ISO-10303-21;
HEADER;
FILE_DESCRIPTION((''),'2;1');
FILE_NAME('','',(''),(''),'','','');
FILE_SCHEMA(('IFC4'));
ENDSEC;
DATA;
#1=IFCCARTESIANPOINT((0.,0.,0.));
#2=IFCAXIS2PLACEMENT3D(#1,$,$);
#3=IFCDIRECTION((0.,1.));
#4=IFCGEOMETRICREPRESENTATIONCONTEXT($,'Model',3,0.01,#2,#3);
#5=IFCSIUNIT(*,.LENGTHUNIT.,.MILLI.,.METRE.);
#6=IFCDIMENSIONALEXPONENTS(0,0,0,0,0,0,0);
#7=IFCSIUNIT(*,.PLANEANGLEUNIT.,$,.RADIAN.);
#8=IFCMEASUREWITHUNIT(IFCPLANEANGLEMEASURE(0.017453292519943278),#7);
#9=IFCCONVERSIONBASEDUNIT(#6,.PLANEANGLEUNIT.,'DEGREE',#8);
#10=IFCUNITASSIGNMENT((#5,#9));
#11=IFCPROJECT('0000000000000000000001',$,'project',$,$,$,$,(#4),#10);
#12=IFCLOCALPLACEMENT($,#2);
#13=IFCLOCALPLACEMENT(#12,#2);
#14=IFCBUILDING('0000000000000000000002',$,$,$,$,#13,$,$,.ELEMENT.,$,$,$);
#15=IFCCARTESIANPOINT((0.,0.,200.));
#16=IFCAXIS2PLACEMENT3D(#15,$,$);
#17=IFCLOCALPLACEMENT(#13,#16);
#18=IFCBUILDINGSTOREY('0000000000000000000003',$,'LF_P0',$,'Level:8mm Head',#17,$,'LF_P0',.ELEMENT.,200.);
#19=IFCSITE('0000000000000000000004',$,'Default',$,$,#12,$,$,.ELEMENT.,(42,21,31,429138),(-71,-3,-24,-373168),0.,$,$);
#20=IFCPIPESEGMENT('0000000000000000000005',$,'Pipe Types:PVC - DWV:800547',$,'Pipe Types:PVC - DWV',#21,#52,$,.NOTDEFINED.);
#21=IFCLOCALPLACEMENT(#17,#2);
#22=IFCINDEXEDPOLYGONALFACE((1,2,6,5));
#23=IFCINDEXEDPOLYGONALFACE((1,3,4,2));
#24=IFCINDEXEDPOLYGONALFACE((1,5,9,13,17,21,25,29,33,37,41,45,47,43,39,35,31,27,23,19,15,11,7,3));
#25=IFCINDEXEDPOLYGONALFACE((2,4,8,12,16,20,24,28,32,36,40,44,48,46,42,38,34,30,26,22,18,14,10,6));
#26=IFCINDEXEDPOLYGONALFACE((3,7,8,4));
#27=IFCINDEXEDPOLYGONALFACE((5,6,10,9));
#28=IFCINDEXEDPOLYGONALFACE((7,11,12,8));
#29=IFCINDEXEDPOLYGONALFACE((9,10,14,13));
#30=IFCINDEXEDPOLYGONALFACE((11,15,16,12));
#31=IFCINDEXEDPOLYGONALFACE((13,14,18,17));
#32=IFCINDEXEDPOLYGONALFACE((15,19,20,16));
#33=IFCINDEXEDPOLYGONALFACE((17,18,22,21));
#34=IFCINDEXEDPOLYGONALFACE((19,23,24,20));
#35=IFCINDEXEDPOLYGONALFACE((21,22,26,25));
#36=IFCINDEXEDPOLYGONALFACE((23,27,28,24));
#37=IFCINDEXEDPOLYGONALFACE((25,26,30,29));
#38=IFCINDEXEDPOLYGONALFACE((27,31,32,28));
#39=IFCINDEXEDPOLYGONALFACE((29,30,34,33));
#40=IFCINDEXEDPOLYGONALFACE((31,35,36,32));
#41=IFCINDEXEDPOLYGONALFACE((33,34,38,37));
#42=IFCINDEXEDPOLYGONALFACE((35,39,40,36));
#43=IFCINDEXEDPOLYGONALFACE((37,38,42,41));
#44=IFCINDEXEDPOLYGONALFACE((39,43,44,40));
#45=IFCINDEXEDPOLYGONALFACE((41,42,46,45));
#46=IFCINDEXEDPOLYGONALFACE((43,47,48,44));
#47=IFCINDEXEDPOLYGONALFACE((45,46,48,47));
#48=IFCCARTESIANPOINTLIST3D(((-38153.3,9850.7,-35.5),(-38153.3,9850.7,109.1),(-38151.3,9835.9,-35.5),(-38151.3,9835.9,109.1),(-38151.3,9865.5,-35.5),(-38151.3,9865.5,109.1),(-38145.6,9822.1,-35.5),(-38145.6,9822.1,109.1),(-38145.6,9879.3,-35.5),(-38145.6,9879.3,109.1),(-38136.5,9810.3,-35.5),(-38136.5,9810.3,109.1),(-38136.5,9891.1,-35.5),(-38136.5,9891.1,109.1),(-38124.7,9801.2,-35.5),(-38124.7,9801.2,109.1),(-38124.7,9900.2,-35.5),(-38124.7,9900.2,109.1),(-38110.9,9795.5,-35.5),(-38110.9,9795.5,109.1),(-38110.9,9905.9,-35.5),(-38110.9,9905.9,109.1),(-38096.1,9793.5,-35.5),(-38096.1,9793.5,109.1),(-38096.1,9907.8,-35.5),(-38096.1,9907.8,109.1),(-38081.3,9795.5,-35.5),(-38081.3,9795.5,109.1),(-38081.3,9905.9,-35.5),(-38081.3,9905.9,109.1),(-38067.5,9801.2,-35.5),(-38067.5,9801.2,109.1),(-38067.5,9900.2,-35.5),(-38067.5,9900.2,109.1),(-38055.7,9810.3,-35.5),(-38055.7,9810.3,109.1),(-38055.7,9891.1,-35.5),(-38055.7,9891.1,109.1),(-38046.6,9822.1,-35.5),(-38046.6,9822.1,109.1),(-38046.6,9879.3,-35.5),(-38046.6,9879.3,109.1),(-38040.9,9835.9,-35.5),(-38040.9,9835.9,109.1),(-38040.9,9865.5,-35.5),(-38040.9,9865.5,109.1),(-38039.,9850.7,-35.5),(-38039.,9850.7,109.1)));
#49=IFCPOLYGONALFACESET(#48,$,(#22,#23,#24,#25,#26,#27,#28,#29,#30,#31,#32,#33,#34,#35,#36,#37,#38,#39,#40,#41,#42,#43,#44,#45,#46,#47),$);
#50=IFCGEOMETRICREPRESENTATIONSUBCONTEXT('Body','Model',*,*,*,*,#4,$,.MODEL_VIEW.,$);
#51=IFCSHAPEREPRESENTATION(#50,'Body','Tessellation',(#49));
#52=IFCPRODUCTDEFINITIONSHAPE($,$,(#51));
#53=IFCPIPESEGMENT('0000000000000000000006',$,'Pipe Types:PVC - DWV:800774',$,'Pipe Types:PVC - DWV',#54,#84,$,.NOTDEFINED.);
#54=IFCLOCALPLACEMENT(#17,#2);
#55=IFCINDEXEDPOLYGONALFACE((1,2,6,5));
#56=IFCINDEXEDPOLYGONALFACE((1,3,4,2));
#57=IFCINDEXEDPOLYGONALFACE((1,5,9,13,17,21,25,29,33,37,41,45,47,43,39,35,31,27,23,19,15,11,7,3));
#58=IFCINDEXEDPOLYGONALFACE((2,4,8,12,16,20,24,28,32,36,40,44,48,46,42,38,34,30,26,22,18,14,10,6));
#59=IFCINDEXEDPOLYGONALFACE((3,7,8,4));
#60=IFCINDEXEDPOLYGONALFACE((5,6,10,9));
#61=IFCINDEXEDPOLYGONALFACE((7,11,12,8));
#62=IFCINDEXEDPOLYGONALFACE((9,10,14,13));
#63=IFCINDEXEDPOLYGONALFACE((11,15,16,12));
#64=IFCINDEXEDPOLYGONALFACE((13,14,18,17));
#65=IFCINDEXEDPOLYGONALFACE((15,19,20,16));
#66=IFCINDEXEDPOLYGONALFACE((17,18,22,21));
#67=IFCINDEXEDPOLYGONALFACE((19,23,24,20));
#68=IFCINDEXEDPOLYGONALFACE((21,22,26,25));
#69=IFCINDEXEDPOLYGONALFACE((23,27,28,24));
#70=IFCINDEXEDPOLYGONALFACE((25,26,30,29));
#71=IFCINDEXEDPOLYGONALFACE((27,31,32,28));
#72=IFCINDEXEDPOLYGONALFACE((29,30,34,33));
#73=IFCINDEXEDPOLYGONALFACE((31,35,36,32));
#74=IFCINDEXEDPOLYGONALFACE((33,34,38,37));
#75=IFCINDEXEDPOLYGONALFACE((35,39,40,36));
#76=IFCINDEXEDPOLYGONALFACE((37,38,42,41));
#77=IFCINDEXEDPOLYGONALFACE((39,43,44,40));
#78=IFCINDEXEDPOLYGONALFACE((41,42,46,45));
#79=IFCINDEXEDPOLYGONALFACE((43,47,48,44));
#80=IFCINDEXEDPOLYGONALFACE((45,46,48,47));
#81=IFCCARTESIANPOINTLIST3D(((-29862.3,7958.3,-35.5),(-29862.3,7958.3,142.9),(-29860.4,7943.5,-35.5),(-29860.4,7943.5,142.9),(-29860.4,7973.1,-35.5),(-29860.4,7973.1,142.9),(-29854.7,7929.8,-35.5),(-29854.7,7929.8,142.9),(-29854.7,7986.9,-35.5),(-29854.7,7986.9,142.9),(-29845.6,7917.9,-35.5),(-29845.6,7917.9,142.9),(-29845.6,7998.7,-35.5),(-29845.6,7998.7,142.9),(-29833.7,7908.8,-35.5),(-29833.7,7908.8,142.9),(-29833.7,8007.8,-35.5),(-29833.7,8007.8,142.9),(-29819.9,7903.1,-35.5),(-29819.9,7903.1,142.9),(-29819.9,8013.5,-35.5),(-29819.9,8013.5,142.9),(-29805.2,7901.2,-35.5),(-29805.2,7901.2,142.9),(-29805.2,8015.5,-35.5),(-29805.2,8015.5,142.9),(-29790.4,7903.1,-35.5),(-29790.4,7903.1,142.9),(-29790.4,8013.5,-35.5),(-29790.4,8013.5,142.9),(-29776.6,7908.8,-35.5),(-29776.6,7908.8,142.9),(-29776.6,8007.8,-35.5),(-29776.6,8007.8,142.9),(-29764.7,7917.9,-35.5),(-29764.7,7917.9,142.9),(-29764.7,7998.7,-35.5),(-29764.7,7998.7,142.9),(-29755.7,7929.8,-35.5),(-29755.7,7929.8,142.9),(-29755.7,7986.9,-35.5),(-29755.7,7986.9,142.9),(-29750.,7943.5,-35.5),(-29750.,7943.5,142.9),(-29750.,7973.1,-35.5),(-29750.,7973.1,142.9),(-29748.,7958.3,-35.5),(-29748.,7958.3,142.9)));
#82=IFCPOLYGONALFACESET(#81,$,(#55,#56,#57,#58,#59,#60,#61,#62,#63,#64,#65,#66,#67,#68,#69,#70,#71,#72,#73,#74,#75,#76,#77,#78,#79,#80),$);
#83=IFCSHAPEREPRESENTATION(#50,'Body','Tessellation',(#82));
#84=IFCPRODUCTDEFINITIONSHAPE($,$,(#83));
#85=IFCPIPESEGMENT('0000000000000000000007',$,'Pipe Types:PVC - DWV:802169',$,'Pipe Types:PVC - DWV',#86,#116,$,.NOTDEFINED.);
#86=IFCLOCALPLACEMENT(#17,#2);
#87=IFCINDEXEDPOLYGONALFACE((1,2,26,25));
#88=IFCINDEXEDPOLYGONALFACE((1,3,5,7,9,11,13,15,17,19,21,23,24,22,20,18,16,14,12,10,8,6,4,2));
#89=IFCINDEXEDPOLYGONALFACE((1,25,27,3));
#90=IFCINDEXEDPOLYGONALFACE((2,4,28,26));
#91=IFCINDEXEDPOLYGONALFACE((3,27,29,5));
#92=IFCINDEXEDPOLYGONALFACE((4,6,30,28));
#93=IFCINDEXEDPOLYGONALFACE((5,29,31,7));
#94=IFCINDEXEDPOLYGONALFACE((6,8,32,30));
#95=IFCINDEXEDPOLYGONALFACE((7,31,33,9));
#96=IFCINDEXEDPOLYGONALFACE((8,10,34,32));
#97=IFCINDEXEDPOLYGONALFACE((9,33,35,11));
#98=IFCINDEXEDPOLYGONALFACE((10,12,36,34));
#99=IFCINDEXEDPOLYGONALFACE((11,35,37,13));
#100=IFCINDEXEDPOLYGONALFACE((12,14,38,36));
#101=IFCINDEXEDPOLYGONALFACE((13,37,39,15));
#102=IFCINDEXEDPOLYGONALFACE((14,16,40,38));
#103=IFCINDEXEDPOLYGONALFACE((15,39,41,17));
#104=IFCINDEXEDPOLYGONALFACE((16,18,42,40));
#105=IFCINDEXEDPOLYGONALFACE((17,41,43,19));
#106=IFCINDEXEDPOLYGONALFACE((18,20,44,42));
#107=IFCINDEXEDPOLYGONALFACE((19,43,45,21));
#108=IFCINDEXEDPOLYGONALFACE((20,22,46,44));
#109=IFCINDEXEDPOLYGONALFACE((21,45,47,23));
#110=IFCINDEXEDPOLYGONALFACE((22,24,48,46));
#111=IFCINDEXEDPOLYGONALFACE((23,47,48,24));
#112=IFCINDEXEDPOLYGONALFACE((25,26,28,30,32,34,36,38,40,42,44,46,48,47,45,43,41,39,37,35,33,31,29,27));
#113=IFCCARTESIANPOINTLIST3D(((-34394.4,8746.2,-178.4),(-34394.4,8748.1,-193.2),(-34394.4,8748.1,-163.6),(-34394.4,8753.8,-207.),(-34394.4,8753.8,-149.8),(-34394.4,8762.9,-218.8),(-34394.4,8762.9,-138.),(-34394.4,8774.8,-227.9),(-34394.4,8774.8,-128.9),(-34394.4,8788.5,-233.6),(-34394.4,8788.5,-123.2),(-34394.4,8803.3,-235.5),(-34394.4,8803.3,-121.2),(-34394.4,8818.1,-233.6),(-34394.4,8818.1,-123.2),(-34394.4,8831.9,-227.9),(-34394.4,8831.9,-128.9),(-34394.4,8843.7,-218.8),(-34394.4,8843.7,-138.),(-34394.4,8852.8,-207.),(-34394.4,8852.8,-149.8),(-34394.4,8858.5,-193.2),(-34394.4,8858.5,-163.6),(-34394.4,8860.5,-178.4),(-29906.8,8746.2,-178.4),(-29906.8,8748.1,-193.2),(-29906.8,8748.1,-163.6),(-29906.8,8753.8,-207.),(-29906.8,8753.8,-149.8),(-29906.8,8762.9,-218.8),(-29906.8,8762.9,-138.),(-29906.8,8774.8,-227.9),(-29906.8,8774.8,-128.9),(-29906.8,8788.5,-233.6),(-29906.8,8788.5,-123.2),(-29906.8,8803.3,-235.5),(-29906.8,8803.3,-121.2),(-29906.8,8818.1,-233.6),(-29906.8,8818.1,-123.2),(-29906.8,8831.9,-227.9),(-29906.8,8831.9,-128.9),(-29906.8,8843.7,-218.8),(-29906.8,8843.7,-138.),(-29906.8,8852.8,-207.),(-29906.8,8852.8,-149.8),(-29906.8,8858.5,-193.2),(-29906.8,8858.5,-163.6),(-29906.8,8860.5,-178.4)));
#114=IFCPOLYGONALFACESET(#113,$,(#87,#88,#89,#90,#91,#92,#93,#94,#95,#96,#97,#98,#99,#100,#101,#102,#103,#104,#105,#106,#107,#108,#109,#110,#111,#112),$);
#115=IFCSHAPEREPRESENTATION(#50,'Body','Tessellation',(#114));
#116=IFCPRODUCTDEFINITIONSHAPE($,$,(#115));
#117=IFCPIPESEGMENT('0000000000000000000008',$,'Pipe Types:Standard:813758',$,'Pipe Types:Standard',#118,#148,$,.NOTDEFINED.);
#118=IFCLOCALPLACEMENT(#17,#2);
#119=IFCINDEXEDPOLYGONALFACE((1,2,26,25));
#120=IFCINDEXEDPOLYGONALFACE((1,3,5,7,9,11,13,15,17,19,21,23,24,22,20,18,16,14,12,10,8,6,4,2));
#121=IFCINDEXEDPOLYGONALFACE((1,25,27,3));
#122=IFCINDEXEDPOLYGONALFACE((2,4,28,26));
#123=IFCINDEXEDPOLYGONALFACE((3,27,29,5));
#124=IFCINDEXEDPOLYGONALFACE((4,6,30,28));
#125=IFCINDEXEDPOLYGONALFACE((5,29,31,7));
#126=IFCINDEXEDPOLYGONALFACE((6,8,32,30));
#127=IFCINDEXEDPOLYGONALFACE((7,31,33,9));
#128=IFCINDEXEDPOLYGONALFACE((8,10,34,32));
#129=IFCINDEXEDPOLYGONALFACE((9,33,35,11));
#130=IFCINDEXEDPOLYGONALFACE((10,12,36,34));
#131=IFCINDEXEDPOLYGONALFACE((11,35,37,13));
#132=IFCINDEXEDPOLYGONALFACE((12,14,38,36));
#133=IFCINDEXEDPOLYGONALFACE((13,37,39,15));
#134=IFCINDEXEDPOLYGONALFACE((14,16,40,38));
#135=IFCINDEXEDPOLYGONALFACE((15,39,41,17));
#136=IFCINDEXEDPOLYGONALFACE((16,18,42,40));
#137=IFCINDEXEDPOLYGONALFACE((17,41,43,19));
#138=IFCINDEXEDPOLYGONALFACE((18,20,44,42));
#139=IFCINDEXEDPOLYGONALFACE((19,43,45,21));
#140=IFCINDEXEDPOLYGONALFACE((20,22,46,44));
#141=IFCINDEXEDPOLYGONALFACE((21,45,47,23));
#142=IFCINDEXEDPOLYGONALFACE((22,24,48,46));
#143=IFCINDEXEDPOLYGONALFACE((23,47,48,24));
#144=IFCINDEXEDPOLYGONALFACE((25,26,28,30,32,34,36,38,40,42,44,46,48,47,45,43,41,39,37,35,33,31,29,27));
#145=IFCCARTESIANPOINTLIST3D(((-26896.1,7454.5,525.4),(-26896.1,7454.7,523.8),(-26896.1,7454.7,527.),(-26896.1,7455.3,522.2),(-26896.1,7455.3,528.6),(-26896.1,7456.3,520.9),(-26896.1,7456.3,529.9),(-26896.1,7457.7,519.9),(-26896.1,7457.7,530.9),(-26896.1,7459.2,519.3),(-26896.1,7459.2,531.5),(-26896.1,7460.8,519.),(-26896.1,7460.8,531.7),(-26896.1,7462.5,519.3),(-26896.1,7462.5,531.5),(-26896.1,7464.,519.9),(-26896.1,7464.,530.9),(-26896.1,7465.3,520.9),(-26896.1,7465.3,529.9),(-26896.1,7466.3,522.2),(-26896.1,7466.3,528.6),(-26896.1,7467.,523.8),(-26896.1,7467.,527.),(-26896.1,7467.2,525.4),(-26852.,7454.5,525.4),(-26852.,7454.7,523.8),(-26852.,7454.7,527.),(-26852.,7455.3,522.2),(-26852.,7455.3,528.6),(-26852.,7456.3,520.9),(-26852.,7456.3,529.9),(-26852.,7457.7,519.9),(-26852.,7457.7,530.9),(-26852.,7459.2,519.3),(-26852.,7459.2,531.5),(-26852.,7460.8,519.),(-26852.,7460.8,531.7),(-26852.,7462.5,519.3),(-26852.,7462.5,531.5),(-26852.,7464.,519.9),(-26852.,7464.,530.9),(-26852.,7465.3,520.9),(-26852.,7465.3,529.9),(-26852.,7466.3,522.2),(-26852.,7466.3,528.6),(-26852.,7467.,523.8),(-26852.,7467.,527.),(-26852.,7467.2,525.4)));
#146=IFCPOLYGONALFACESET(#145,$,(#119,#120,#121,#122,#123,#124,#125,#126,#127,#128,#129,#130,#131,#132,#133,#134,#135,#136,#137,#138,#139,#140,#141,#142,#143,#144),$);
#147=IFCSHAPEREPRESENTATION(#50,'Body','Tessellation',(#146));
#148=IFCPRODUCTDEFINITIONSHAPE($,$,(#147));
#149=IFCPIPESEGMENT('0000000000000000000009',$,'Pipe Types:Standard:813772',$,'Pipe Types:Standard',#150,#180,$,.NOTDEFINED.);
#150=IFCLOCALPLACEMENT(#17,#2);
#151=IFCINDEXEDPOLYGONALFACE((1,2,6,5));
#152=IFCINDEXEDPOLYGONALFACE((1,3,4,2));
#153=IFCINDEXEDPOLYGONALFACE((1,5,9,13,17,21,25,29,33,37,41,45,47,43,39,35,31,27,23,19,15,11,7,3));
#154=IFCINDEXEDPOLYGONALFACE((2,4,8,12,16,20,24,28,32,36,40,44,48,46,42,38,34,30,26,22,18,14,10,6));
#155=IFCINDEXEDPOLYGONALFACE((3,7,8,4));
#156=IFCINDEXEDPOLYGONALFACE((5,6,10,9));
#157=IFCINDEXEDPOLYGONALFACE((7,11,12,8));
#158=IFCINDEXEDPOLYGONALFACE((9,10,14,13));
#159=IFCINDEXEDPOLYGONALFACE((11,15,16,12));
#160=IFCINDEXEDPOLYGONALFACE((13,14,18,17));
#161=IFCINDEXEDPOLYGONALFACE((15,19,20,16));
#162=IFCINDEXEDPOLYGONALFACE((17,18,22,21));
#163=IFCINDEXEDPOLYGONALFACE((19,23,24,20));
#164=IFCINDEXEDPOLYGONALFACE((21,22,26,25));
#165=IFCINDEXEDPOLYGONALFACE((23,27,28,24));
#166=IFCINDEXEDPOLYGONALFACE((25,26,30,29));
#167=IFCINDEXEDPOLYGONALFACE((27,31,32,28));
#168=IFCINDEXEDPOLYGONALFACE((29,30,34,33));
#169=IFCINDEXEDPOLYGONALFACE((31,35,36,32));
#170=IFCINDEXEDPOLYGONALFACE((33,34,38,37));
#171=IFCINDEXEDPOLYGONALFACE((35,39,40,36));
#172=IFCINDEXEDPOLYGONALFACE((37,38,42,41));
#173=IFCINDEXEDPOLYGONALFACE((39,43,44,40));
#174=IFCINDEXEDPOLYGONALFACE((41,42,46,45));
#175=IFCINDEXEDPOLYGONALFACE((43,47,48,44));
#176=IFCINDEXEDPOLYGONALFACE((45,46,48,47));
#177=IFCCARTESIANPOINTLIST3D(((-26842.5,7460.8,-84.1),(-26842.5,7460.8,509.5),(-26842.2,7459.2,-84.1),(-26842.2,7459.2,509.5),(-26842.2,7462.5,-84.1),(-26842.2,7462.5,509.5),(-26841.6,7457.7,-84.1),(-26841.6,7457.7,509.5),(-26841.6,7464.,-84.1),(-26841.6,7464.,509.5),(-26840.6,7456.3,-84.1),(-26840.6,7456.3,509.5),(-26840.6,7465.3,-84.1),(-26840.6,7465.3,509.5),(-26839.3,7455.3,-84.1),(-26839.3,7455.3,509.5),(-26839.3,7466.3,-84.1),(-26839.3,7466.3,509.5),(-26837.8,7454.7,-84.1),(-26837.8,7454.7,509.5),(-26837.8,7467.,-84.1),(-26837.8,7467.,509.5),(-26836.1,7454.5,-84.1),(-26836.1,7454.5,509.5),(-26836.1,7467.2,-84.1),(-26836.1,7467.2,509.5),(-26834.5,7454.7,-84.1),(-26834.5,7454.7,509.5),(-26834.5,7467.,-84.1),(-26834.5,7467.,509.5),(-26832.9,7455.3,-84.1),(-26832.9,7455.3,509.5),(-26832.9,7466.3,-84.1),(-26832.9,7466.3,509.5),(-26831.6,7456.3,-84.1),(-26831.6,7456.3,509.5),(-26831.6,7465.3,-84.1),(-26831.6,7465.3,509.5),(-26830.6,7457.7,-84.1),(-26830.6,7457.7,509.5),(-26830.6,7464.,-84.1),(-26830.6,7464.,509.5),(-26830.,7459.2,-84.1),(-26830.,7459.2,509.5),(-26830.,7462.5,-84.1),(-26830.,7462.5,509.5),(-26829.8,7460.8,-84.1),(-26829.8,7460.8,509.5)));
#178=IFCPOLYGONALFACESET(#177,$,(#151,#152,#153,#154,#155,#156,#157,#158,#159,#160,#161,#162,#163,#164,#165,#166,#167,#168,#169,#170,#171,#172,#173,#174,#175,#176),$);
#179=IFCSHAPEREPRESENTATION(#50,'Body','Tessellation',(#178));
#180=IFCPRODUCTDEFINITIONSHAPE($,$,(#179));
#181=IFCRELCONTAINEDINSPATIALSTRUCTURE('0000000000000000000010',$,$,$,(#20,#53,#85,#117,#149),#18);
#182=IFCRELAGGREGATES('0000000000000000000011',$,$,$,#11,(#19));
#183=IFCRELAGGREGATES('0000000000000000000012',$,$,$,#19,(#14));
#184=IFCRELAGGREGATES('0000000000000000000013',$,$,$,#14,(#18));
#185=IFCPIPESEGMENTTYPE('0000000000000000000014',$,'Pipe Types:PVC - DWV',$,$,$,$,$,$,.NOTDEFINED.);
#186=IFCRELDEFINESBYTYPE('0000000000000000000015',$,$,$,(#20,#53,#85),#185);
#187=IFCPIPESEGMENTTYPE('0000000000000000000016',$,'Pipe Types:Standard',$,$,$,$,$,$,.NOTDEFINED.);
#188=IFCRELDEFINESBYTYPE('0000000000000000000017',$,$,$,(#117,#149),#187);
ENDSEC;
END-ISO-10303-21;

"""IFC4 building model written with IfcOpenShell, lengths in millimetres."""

from ifc_helpers import new_model, entity, si_unit, converted_unit, direction, frame, origin, place, context, subcontext, project, spatial, arc, indexed_curve, outline, extrude, type_object, element, save


model = new_model("IFC4")

# Units and contexts
model_context = context("Model", 3, precision=0.01, world=origin(), true_north=direction((0.0, 1.0)))
body_context = subcontext(model_context, "Body", "Model", "MODEL_VIEW")
ifc_project = project(units=[si_unit("LENGTHUNIT", "METRE", prefix="MILLI"), converted_unit("PLANEANGLEUNIT", "DEGREE", entity("IfcPlaneAngleMeasure", 0.017453292519943278), si_unit("PLANEANGLEUNIT", "RADIAN"), dimensions=[0, 0, 0, 0, 0, 0, 0])], contexts=[model_context])

# Site, building, storey
site_placement = place(None, origin())
site = spatial("IfcSite", under=ifc_project, at=site_placement, Name="Default", CompositionType="ELEMENT", RefLatitude=(42, 21, 31, 429138), RefLongitude=(-71, -3, -24, -373168), RefElevation=0.0)
building_placement = place(site_placement, origin())
building = spatial("IfcBuilding", under=site, at=building_placement, CompositionType="ELEMENT")
storey_placement = place(building_placement, frame((0.0, 0.0, 200.0)))
storey = spatial("IfcBuildingStorey", under=building, at=storey_placement, Name="LF_P0", ObjectType="Level:8mm Head", LongName="LF_P0", CompositionType="ELEMENT", Elevation=200.0)

# Pipe segments
pipe_segment_type_1 = type_object("IfcPipeSegmentType", Name="Pipe Types:PVC - DWV", PredefinedType="NOTDEFINED")
pipe_segment_1_placement = place(storey_placement, origin())
element("IfcPipeSegment", 1, at=pipe_segment_1_placement, inside=storey, type_object=pipe_segment_type_1, Name="Pipe Types:PVC - DWV:800547", ObjectType="Pipe Types:PVC - DWV", PredefinedType="NOTDEFINED", context=body_context, shape_type="SweptSolid", body=[
    extrude(outline(indexed_curve([(57.2, 0.0), (40.4, 40.4), (0.0, 57.2), (-40.4, 40.4), (-57.2, 0.0), (-40.4, -40.4), (0.0, -57.2), (40.4, -40.4)], segments=[arc(1, 2, 3), arc(3, 4, 5), arc(5, 6, 7), arc(7, 8, 1)], self_intersect=False)), frame((-38096.1, 9850.7, -35.5)), (0.0, 0.0, 1.0), 144.6),
])
pipe_segment_2_placement = place(storey_placement, origin())
element("IfcPipeSegment", 2, at=pipe_segment_2_placement, inside=storey, type_object=pipe_segment_type_1, Name="Pipe Types:PVC - DWV:800774", ObjectType="Pipe Types:PVC - DWV", PredefinedType="NOTDEFINED", context=body_context, shape_type="SweptSolid", body=[
    extrude(outline(indexed_curve([(57.2, 0.0), (40.4, 40.4), (0.0, 57.2), (-40.4, 40.4), (-57.2, 0.0), (-40.4, -40.4), (0.0, -57.2), (40.4, -40.4)], segments=[arc(1, 2, 3), arc(3, 4, 5), arc(5, 6, 7), arc(7, 8, 1)], self_intersect=False)), frame((-29805.2, 7958.3, -35.5), z_axis=(0.0, 0.0, 1.0), x_axis=(-1.0, 0.0, 0.0)), (0.0, 0.0, 1.0), 178.4),
])
pipe_segment_3_placement = place(storey_placement, origin())
element("IfcPipeSegment", 3, at=pipe_segment_3_placement, inside=storey, type_object=pipe_segment_type_1, Name="Pipe Types:PVC - DWV:802169", ObjectType="Pipe Types:PVC - DWV", PredefinedType="NOTDEFINED", context=body_context, shape_type="SweptSolid", body=[
    extrude(outline(indexed_curve([(57.1, 0.0), (40.4, 40.4), (0.0, 57.1), (-40.4, 40.4), (-57.2, 0.0), (-40.4, -40.4), (0.0, -57.2), (40.4, -40.4)], segments=[arc(1, 2, 3), arc(3, 4, 5), arc(5, 6, 7), arc(7, 8, 1)], self_intersect=False)), frame((-34394.4, 8803.3, -178.4), z_axis=(1.0, 0.0, 0.0), x_axis=(0.0, 1.0, 0.0)), (0.0, 0.0, 1.0), 4487.6),
])
pipe_segment_type_2 = type_object("IfcPipeSegmentType", Name="Pipe Types:Standard", PredefinedType="NOTDEFINED")
pipe_segment_4_placement = place(storey_placement, origin())
element("IfcPipeSegment", 4, at=pipe_segment_4_placement, inside=storey, type_object=pipe_segment_type_2, Name="Pipe Types:Standard:813758", ObjectType="Pipe Types:Standard", PredefinedType="NOTDEFINED", context=body_context, shape_type="SweptSolid", body=[
    extrude(outline(indexed_curve([(6.3, 0.0), (4.5, 4.5), (0.0, 6.4), (-4.5, 4.5), (-6.3, 0.0), (-4.5, -4.5), (0.0, -6.4), (4.5, -4.5)], segments=[arc(1, 2, 3), arc(3, 4, 5), arc(5, 6, 7), arc(7, 8, 1)], self_intersect=False)), frame((-26896.1, 7460.8, 525.4), z_axis=(1.0, 0.0, 0.0), x_axis=(0.0, -1.0, 0.0)), (0.0, 0.0, 1.0), 44.1),
])
pipe_segment_5_placement = place(storey_placement, origin())
element("IfcPipeSegment", 5, at=pipe_segment_5_placement, inside=storey, type_object=pipe_segment_type_2, Name="Pipe Types:Standard:813772", ObjectType="Pipe Types:Standard", PredefinedType="NOTDEFINED", context=body_context, shape_type="SweptSolid", body=[
    extrude(outline(indexed_curve([(6.3, 0.0), (4.5, 4.5), (0.0, 6.4), (-4.5, 4.5), (-6.3, 0.0), (-4.5, -4.5), (0.0, -6.3), (4.5, -4.5)], segments=[arc(1, 2, 3), arc(3, 4, 5), arc(5, 6, 7), arc(7, 8, 1)], self_intersect=False)), frame((-26836.1, 7460.8, -84.1)), (0.0, 0.0, 1.0), 593.6),
])

save(model, "model.ifc")
